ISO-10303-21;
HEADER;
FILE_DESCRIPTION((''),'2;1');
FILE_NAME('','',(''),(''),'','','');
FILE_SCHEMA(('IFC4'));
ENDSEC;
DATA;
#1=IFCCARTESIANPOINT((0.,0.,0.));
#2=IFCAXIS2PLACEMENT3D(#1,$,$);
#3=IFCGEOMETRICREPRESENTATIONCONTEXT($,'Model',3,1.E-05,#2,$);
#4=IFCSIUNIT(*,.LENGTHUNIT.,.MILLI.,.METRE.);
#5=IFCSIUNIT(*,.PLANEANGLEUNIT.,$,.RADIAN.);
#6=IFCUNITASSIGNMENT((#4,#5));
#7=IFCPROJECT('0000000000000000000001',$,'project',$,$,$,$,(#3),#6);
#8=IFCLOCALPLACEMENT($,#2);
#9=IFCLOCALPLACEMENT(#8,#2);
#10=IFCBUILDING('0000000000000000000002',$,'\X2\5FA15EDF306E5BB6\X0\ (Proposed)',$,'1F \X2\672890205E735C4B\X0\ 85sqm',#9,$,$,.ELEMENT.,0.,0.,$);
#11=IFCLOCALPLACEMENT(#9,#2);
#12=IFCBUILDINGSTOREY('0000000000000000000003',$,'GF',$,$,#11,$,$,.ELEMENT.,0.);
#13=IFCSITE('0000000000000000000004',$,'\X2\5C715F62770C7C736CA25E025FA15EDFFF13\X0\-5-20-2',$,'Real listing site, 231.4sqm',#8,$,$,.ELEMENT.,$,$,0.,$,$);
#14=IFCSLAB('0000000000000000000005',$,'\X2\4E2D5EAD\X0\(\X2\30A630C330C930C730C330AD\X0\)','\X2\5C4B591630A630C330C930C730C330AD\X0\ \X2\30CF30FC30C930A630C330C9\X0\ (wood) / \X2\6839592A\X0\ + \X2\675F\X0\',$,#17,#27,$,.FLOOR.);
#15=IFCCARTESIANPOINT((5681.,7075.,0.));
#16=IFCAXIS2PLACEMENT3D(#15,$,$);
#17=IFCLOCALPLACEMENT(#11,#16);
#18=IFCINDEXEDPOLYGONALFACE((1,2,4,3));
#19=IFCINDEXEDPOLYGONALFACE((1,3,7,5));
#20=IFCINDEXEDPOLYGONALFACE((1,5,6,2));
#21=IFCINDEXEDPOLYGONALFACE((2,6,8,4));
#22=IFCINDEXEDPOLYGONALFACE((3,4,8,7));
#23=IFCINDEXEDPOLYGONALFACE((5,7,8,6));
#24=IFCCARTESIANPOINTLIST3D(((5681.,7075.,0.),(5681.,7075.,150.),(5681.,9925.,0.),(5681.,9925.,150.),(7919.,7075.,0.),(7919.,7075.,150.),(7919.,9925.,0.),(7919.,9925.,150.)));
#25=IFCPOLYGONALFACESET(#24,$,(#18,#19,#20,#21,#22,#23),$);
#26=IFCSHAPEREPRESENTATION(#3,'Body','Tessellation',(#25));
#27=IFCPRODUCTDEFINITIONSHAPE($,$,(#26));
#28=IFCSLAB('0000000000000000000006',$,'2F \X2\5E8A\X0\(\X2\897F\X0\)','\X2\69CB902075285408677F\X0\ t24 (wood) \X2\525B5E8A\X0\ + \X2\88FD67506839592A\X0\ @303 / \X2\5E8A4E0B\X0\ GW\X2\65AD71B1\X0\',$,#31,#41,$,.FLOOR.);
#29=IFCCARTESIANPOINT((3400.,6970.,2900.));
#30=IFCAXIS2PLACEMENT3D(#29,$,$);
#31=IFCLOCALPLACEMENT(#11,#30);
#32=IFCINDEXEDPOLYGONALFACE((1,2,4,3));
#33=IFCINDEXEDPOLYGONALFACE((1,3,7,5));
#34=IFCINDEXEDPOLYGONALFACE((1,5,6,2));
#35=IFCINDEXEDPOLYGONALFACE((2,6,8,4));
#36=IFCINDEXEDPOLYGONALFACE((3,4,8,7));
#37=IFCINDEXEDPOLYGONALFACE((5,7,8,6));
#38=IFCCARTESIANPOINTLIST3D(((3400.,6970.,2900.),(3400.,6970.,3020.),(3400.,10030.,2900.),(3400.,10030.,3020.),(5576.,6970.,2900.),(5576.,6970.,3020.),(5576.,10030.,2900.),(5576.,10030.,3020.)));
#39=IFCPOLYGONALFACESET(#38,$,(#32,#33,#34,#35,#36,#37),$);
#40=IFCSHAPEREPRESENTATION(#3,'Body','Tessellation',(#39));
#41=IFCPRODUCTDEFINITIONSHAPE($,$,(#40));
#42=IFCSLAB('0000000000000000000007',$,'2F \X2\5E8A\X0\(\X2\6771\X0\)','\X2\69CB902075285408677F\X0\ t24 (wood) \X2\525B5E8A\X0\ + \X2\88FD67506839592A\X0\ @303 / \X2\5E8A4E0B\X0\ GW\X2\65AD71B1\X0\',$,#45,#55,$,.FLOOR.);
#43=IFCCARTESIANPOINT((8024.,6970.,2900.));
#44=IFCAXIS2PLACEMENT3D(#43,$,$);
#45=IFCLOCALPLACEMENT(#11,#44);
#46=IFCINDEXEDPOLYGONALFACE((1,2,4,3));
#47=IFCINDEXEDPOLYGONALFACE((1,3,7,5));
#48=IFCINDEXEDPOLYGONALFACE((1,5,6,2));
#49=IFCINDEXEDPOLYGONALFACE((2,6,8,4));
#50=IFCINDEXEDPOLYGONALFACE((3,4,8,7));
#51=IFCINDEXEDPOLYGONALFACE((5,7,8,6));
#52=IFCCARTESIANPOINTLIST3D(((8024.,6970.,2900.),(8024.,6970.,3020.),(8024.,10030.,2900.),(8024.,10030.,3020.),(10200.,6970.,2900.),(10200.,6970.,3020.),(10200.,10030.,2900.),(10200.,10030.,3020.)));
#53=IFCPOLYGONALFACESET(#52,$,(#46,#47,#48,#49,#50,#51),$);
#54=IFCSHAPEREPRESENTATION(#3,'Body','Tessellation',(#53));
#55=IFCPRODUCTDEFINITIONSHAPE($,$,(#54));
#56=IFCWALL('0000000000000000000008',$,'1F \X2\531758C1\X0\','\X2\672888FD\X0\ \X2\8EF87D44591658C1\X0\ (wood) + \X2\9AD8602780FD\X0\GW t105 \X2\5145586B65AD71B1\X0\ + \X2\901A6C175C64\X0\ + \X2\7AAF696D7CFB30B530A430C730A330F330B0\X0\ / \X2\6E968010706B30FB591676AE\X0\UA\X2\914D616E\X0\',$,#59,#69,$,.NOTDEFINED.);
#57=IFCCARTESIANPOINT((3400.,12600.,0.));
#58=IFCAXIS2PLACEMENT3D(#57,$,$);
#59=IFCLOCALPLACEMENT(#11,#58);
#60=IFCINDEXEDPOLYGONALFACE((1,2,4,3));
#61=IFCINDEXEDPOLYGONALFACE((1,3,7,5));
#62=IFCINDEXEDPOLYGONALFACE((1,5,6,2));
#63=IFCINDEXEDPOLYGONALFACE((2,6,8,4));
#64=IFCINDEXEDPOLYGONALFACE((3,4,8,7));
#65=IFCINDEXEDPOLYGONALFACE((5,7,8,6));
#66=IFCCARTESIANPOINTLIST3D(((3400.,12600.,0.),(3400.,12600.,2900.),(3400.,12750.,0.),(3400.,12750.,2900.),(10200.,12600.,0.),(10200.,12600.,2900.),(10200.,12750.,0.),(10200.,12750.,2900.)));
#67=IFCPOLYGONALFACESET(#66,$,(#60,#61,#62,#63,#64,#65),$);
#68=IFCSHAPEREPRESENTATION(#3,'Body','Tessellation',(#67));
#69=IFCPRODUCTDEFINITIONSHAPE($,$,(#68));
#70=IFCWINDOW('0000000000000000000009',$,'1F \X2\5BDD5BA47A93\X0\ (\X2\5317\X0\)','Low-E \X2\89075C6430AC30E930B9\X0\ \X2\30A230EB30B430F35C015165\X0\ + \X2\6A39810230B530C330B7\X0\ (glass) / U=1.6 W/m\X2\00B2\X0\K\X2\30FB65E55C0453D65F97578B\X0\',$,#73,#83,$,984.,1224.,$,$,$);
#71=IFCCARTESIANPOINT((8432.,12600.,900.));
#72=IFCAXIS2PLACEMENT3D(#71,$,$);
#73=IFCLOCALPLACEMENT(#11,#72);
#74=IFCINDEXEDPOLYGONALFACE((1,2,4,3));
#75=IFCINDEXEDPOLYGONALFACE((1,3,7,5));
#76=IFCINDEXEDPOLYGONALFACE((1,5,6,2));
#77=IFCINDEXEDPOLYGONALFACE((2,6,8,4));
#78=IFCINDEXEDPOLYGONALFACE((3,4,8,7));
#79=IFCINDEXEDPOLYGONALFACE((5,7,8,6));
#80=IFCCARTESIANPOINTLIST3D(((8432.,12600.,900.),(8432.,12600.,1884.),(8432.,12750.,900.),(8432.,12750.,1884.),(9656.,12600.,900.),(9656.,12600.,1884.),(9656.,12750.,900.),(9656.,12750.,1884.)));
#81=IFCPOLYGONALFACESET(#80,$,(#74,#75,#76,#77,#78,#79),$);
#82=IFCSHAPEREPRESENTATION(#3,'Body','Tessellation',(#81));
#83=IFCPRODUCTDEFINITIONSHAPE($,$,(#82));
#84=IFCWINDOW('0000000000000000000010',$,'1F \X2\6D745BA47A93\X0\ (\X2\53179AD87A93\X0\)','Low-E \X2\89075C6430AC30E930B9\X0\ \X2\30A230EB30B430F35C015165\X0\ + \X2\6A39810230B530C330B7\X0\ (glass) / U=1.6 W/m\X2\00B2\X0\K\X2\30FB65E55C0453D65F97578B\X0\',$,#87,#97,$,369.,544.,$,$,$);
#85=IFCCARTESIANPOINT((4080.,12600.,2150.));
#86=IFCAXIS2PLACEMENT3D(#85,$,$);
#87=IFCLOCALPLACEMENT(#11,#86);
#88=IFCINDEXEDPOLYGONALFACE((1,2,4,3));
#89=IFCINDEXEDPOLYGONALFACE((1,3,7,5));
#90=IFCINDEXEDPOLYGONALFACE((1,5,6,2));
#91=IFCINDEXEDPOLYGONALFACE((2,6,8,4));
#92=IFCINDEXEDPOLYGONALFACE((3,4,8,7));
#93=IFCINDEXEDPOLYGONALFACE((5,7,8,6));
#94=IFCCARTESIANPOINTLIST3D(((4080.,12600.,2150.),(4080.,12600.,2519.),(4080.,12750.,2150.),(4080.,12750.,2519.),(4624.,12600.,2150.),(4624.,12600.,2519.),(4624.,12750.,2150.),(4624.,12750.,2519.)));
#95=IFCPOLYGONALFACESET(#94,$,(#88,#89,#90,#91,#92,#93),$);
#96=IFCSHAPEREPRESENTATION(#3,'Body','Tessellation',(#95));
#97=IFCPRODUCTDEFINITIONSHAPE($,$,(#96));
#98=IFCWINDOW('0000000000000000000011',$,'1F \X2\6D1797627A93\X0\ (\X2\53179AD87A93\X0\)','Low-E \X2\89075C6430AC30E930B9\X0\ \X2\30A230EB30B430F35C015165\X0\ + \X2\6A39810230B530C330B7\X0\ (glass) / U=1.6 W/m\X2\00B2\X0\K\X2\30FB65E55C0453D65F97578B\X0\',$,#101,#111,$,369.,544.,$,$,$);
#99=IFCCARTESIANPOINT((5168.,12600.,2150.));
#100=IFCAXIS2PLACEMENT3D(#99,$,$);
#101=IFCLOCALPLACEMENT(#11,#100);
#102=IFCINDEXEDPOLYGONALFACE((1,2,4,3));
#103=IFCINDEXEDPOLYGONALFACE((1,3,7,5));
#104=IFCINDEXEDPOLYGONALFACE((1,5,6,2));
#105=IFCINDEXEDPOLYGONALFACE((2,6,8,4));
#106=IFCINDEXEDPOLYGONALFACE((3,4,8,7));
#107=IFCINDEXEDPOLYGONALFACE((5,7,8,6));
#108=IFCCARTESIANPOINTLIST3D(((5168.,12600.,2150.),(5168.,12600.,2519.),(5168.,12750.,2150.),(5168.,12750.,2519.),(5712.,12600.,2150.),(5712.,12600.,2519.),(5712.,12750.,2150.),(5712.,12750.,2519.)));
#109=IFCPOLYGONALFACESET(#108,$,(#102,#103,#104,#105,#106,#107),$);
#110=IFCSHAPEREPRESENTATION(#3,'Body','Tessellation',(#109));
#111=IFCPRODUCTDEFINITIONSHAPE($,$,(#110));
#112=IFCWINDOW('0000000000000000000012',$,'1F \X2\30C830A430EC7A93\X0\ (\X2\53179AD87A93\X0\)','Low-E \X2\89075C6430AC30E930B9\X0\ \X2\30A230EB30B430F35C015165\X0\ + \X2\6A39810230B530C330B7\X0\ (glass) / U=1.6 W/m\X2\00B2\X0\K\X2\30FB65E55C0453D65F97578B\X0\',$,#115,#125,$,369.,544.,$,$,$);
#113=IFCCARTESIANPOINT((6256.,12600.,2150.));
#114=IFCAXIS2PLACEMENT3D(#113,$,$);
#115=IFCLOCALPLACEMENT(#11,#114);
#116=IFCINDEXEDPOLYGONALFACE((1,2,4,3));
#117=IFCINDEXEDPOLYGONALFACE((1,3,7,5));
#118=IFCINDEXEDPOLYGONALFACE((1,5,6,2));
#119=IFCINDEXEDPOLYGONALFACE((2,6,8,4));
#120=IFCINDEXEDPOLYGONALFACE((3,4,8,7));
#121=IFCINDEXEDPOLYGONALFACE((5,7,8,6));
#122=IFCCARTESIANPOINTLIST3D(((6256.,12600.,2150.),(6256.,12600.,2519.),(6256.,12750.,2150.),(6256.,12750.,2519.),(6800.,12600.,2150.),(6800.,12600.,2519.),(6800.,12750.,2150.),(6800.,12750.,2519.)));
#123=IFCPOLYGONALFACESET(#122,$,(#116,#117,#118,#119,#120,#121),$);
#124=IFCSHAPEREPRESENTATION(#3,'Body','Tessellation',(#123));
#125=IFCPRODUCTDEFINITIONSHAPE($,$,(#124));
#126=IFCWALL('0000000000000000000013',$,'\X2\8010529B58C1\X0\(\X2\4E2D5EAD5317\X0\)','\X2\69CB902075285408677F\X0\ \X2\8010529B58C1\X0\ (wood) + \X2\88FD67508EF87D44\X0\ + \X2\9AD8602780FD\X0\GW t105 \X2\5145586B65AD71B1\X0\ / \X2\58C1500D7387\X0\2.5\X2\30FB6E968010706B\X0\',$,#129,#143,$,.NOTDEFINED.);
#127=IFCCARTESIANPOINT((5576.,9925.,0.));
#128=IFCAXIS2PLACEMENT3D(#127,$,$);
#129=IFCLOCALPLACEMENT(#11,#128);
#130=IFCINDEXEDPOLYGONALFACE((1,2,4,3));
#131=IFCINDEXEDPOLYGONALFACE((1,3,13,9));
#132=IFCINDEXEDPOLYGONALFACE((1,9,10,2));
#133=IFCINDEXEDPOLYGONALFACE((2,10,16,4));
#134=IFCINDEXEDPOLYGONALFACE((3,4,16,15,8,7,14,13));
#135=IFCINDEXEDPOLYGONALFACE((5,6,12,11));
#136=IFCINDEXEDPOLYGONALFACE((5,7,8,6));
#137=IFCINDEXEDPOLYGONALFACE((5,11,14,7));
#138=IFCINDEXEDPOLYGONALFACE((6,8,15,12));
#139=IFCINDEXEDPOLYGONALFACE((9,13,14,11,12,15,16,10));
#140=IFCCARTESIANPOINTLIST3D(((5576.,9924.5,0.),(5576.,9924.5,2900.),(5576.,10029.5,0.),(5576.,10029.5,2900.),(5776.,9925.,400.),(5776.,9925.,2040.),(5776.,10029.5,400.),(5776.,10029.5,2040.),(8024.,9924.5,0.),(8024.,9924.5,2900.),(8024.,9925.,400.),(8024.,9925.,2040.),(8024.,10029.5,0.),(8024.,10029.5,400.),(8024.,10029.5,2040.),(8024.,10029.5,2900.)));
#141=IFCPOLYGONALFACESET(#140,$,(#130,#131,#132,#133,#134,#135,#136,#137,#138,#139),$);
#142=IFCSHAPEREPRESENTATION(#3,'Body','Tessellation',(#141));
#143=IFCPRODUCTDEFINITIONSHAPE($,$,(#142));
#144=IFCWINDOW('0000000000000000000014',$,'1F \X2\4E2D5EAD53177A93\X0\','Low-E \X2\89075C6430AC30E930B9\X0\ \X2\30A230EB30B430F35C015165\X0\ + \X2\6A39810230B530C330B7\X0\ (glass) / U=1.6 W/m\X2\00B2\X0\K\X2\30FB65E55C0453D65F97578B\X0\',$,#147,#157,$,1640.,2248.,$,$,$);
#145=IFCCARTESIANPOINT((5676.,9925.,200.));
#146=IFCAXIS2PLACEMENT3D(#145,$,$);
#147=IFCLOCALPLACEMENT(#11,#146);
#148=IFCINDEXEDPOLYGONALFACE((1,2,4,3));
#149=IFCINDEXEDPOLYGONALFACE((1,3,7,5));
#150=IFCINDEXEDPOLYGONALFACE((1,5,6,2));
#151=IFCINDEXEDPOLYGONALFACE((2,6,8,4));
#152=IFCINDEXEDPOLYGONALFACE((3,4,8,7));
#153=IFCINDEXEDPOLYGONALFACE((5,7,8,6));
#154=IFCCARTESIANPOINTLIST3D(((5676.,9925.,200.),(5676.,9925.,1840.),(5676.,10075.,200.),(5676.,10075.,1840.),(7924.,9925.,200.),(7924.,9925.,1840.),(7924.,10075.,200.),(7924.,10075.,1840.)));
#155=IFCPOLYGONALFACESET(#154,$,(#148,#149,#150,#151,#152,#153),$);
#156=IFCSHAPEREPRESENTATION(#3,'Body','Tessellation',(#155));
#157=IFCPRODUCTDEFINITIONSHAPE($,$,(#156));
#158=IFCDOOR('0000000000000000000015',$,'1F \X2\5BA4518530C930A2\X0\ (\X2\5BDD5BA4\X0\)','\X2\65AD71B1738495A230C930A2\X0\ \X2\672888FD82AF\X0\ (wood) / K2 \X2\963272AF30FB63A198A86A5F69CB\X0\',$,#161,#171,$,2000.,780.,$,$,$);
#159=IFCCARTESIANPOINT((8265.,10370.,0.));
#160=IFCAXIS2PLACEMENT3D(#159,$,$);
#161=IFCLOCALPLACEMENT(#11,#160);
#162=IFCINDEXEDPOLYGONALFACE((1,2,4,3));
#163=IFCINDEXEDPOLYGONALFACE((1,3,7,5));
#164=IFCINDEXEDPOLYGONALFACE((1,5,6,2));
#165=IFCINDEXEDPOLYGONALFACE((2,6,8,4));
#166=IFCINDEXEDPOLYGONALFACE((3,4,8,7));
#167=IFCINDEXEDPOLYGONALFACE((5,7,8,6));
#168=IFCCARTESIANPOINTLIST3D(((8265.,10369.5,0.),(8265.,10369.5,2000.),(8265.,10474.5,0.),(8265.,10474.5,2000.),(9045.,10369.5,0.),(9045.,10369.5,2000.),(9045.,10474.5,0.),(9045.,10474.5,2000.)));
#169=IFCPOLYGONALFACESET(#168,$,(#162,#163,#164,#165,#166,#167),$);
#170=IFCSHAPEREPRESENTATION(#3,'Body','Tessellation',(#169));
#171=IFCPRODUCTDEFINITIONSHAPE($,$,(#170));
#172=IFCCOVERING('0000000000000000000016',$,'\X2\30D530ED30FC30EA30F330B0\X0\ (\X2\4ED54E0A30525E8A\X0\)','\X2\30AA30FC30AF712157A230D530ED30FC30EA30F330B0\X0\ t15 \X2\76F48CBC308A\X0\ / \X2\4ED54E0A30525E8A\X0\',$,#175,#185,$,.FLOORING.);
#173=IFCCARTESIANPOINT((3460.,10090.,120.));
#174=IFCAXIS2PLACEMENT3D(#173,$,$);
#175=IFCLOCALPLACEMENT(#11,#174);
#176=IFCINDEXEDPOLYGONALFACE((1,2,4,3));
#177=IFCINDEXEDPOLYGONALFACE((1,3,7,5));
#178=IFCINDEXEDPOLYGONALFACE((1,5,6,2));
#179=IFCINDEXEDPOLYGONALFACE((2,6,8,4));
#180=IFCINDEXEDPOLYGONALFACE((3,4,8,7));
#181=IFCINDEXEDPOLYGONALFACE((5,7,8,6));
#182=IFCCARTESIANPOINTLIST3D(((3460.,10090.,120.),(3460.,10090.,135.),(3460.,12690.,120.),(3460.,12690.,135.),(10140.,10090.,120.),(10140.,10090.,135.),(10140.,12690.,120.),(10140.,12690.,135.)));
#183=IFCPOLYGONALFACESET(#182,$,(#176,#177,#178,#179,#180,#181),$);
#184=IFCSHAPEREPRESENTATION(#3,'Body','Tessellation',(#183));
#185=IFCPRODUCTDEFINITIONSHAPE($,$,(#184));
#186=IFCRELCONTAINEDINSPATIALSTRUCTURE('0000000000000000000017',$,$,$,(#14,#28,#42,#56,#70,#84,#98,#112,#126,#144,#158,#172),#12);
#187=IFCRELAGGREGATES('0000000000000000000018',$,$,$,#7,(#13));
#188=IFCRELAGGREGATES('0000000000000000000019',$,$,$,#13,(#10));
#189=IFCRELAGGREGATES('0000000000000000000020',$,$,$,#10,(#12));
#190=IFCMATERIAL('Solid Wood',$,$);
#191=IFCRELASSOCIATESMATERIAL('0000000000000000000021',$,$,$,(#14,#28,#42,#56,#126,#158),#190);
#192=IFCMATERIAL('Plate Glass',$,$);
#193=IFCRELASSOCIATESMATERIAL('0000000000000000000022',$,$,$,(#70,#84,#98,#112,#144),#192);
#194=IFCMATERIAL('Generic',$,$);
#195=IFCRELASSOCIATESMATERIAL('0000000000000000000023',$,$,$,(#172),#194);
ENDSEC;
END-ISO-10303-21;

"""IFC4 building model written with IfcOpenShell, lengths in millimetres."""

from ifc_helpers import new_model, si_unit, frame, frame_2d, origin, place, context, project, spatial, rectangle, extrude, material, element, fill, save


model = new_model("IFC4")

# Units and contexts
model_context = context("Model", 3, precision=1e-05, world=origin())
ifc_project = project(units=[si_unit("LENGTHUNIT", "METRE", prefix="MILLI"), si_unit("PLANEANGLEUNIT", "RADIAN")], contexts=[model_context])

# Site, building, storey
site_placement = place(None, origin())
site = spatial("IfcSite", under=ifc_project, at=site_placement, Name="山形県米沢市御廟３-5-20-2", ObjectType="Real listing site, 231.4sqm", CompositionType="ELEMENT", RefElevation=0.0)
building_placement = place(site_placement, origin())
building = spatial("IfcBuilding", under=site, at=building_placement, Name="御廟の家 (Proposed)", ObjectType="1F 木造平屋 85sqm", CompositionType="ELEMENT", ElevationOfRefHeight=0.0, ElevationOfTerrain=0.0)
storey_placement = place(building_placement, origin())
storey = spatial("IfcBuildingStorey", under=building, at=storey_placement, Name="GF", CompositionType="ELEMENT", Elevation=0.0)

# Slabs
ifc_material_1 = material(Name="Solid Wood")
slab_1_placement = place(storey_placement, frame((5681.0, 7075.0, 0.0)))
element("IfcSlab", 1, at=slab_1_placement, inside=storey, material=ifc_material_1, Name="中庭(ウッドデッキ)", Description="屋外ウッドデッキ ハードウッド (wood) / 根太 + 束", PredefinedType="FLOOR", context=model_context, shape_type="SweptSolid", body=[
    extrude(rectangle(XDim=2238.0, YDim=2850.0, at=frame_2d((1119.0, 1425.0))), frame((5681.0, 7075.0, 0.0)), (0.0, 0.0, 1.0), 150.0),
])
slab_2_placement = place(storey_placement, frame((3400.0, 6970.0, 2900.0)))
element("IfcSlab", 2, at=slab_2_placement, inside=storey, material=ifc_material_1, Name="2F 床(西)", Description="構造用合板 t24 (wood) 剛床 + 製材根太 @303 / 床下 GW断熱", PredefinedType="FLOOR", context=model_context, shape_type="SweptSolid", body=[
    extrude(rectangle(XDim=2176.0, YDim=3060.0, at=frame_2d((1088.0, 1530.0))), frame((3400.0, 6970.0, 2900.0)), (0.0, 0.0, 1.0), 120.0),
])
slab_3_placement = place(storey_placement, frame((8024.0, 6970.0, 2900.0)))
element("IfcSlab", 3, at=slab_3_placement, inside=storey, material=ifc_material_1, Name="2F 床(東)", Description="構造用合板 t24 (wood) 剛床 + 製材根太 @303 / 床下 GW断熱", PredefinedType="FLOOR", context=model_context, shape_type="SweptSolid", body=[
    extrude(rectangle(XDim=2176.0, YDim=3060.0, at=frame_2d((1088.0, 1530.0))), frame((8024.0, 6970.0, 2900.0)), (0.0, 0.0, 1.0), 120.0),
])

# Wall, openings, windows
wall_1_placement = place(storey_placement, frame((3400.0, 12600.0, 0.0)))
wall_1 = element("IfcWall", 4, at=wall_1_placement, inside=storey, material=ifc_material_1, Name="1F 北壁", Description="木製 軸組外壁 (wood) + 高性能GW t105 充填断熱 + 通気層 + 窯業系サイディング / 準耐火・外皮UA配慮", PredefinedType="NOTDEFINED", context=model_context, shape_type="SweptSolid", body=[
    extrude(rectangle(XDim=6800.0, YDim=150.0, at=frame_2d((3400.0, 75.0))), frame((3400.0, 12600.0, 0.0)), (0.0, 0.0, 1.0), 2900.0),
])
opening_1_placement = place(storey_placement, frame((8432.0, 12600.0, 900.0)))
opening_1 = element("IfcOpeningElement", 5, at=opening_1_placement, cuts=wall_1, PredefinedType="NOTDEFINED", context=model_context, shape_type="SweptSolid", body=[
    extrude(rectangle(XDim=1224.0, YDim=150.0, at=frame_2d((612.0, 75.0))), frame((8432.0, 12600.0, 900.0)), (0.0, 0.0, 1.0), 984.0),
])
opening_2_placement = place(storey_placement, frame((4080.0, 12600.0, 2150.0)))
opening_2 = element("IfcOpeningElement", 6, at=opening_2_placement, cuts=wall_1, PredefinedType="NOTDEFINED", context=model_context, shape_type="SweptSolid", body=[
    extrude(rectangle(XDim=544.0, YDim=150.0, at=frame_2d((272.0, 75.0))), frame((4080.0, 12600.0, 2150.0)), (0.0, 0.0, 1.0), 369.0),
])
opening_3_placement = place(storey_placement, frame((5168.0, 12600.0, 2150.0)))
opening_3 = element("IfcOpeningElement", 7, at=opening_3_placement, cuts=wall_1, PredefinedType="NOTDEFINED", context=model_context, shape_type="SweptSolid", body=[
    extrude(rectangle(XDim=544.0, YDim=150.0, at=frame_2d((272.0, 75.0))), frame((5168.0, 12600.0, 2150.0)), (0.0, 0.0, 1.0), 369.0),
])
opening_4_placement = place(storey_placement, frame((6256.0, 12600.0, 2150.0)))
opening_4 = element("IfcOpeningElement", 8, at=opening_4_placement, cuts=wall_1, PredefinedType="NOTDEFINED", context=model_context, shape_type="SweptSolid", body=[
    extrude(rectangle(XDim=544.0, YDim=150.0, at=frame_2d((272.0, 75.0))), frame((6256.0, 12600.0, 2150.0)), (0.0, 0.0, 1.0), 369.0),
])
ifc_material_2 = material(Name="Plate Glass")
window_1_placement = place(storey_placement, frame((8432.0, 12600.0, 900.0)))
window_1 = element("IfcWindow", 9, at=window_1_placement, inside=storey, material=ifc_material_2, Name="1F 寝室窓 (北)", Description="Low-E 複層ガラス アルゴン封入 + 樹脂サッシ (glass) / U=1.6 W/m²K・日射取得型", OverallHeight=984.0, OverallWidth=1224.0, context=model_context, shape_type="SweptSolid", body=[
    extrude(rectangle(XDim=1224.0, YDim=150.0, at=frame_2d((612.0, 75.0))), frame((8432.0, 12600.0, 900.0)), (0.0, 0.0, 1.0), 984.0),
])
fill(opening_1, window_1)
window_2_placement = place(storey_placement, frame((4080.0, 12600.0, 2150.0)))
window_2 = element("IfcWindow", 10, at=window_2_placement, inside=storey, material=ifc_material_2, Name="1F 浴室窓 (北高窓)", Description="Low-E 複層ガラス アルゴン封入 + 樹脂サッシ (glass) / U=1.6 W/m²K・日射取得型", OverallHeight=369.0, OverallWidth=544.0, context=model_context, shape_type="SweptSolid", body=[
    extrude(rectangle(XDim=544.0, YDim=150.0, at=frame_2d((272.0, 75.0))), frame((4080.0, 12600.0, 2150.0)), (0.0, 0.0, 1.0), 369.0),
])
fill(opening_2, window_2)
window_3_placement = place(storey_placement, frame((5168.0, 12600.0, 2150.0)))
window_3 = element("IfcWindow", 11, at=window_3_placement, inside=storey, material=ifc_material_2, Name="1F 洗面窓 (北高窓)", Description="Low-E 複層ガラス アルゴン封入 + 樹脂サッシ (glass) / U=1.6 W/m²K・日射取得型", OverallHeight=369.0, OverallWidth=544.0, context=model_context, shape_type="SweptSolid", body=[
    extrude(rectangle(XDim=544.0, YDim=150.0, at=frame_2d((272.0, 75.0))), frame((5168.0, 12600.0, 2150.0)), (0.0, 0.0, 1.0), 369.0),
])
fill(opening_3, window_3)
window_4_placement = place(storey_placement, frame((6256.0, 12600.0, 2150.0)))
window_4 = element("IfcWindow", 12, at=window_4_placement, inside=storey, material=ifc_material_2, Name="1F トイレ窓 (北高窓)", Description="Low-E 複層ガラス アルゴン封入 + 樹脂サッシ (glass) / U=1.6 W/m²K・日射取得型", OverallHeight=369.0, OverallWidth=544.0, context=model_context, shape_type="SweptSolid", body=[
    extrude(rectangle(XDim=544.0, YDim=150.0, at=frame_2d((272.0, 75.0))), frame((6256.0, 12600.0, 2150.0)), (0.0, 0.0, 1.0), 369.0),
])
fill(opening_4, window_4)

# Wall, opening, window
wall_2_placement = place(storey_placement, frame((5576.0, 9925.0, 0.0)))
wall_2 = element("IfcWall", 13, at=wall_2_placement, inside=storey, material=ifc_material_1, Name="耐力壁(中庭北)", Description="構造用合板 耐力壁 (wood) + 製材軸組 + 高性能GW t105 充填断熱 / 壁倍率2.5・準耐火", PredefinedType="NOTDEFINED", context=model_context, shape_type="SweptSolid", body=[
    extrude(rectangle(XDim=2448.0, YDim=105.0, at=frame_2d((1224.0, 52.0))), frame((5576.0, 9925.0, 0.0)), (0.0, 0.0, 1.0), 2900.0),
])
opening_5_placement = place(storey_placement, frame((5676.0, 9925.0, 200.0)))
opening_5 = element("IfcOpeningElement", 14, at=opening_5_placement, cuts=wall_2, PredefinedType="NOTDEFINED", context=model_context, shape_type="SweptSolid", body=[
    extrude(rectangle(XDim=2248.0, YDim=150.0, at=frame_2d((1124.0, 75.0))), frame((5676.0, 9925.0, 200.0)), (0.0, 0.0, 1.0), 1640.0),
])
window_5_placement = place(storey_placement, frame((5676.0, 9925.0, 200.0)))
window_5 = element("IfcWindow", 15, at=window_5_placement, inside=storey, material=ifc_material_2, Name="1F 中庭北窓", Description="Low-E 複層ガラス アルゴン封入 + 樹脂サッシ (glass) / U=1.6 W/m²K・日射取得型", OverallHeight=1640.0, OverallWidth=2248.0, context=model_context, shape_type="SweptSolid", body=[
    extrude(rectangle(XDim=2248.0, YDim=150.0, at=frame_2d((1124.0, 75.0))), frame((5676.0, 9925.0, 200.0)), (0.0, 0.0, 1.0), 1640.0),
])
fill(opening_5, window_5)

# Door
door_1_placement = place(storey_placement, frame((8265.0, 10370.0, 0.0)))
element("IfcDoor", 16, at=door_1_placement, inside=storey, material=ifc_material_1, Name="1F 室内ドア (寝室)", Description="断熱玄関ドア 木製芯 (wood) / K2 防犯・採風機構", OverallHeight=2000.0, OverallWidth=780.0, context=model_context, shape_type="SweptSolid", body=[
    extrude(rectangle(XDim=780.0, YDim=105.0, at=frame_2d((390.0, 52.0))), frame((8265.0, 10370.0, 0.0)), (0.0, 0.0, 1.0), 2000.0),
])

# Covering
ifc_material_3 = material(Name="Generic")
covering_1_placement = place(storey_placement, frame((3460.0, 10090.0, 120.0)))
element("IfcCovering", 17, at=covering_1_placement, inside=storey, material=ifc_material_3, Name="フローリング (仕上げ床)", Description="オーク無垢フローリング t15 直貼り / 仕上げ床", PredefinedType="FLOORING", context=model_context, shape_type="SweptSolid", body=[
    extrude(rectangle(XDim=6680.0, YDim=2600.0, at=frame_2d((3340.0, 1300.0))), frame((3460.0, 10090.0, 120.0)), (0.0, 0.0, 1.0), 15.0),
])

save(model, "model.ifc")
